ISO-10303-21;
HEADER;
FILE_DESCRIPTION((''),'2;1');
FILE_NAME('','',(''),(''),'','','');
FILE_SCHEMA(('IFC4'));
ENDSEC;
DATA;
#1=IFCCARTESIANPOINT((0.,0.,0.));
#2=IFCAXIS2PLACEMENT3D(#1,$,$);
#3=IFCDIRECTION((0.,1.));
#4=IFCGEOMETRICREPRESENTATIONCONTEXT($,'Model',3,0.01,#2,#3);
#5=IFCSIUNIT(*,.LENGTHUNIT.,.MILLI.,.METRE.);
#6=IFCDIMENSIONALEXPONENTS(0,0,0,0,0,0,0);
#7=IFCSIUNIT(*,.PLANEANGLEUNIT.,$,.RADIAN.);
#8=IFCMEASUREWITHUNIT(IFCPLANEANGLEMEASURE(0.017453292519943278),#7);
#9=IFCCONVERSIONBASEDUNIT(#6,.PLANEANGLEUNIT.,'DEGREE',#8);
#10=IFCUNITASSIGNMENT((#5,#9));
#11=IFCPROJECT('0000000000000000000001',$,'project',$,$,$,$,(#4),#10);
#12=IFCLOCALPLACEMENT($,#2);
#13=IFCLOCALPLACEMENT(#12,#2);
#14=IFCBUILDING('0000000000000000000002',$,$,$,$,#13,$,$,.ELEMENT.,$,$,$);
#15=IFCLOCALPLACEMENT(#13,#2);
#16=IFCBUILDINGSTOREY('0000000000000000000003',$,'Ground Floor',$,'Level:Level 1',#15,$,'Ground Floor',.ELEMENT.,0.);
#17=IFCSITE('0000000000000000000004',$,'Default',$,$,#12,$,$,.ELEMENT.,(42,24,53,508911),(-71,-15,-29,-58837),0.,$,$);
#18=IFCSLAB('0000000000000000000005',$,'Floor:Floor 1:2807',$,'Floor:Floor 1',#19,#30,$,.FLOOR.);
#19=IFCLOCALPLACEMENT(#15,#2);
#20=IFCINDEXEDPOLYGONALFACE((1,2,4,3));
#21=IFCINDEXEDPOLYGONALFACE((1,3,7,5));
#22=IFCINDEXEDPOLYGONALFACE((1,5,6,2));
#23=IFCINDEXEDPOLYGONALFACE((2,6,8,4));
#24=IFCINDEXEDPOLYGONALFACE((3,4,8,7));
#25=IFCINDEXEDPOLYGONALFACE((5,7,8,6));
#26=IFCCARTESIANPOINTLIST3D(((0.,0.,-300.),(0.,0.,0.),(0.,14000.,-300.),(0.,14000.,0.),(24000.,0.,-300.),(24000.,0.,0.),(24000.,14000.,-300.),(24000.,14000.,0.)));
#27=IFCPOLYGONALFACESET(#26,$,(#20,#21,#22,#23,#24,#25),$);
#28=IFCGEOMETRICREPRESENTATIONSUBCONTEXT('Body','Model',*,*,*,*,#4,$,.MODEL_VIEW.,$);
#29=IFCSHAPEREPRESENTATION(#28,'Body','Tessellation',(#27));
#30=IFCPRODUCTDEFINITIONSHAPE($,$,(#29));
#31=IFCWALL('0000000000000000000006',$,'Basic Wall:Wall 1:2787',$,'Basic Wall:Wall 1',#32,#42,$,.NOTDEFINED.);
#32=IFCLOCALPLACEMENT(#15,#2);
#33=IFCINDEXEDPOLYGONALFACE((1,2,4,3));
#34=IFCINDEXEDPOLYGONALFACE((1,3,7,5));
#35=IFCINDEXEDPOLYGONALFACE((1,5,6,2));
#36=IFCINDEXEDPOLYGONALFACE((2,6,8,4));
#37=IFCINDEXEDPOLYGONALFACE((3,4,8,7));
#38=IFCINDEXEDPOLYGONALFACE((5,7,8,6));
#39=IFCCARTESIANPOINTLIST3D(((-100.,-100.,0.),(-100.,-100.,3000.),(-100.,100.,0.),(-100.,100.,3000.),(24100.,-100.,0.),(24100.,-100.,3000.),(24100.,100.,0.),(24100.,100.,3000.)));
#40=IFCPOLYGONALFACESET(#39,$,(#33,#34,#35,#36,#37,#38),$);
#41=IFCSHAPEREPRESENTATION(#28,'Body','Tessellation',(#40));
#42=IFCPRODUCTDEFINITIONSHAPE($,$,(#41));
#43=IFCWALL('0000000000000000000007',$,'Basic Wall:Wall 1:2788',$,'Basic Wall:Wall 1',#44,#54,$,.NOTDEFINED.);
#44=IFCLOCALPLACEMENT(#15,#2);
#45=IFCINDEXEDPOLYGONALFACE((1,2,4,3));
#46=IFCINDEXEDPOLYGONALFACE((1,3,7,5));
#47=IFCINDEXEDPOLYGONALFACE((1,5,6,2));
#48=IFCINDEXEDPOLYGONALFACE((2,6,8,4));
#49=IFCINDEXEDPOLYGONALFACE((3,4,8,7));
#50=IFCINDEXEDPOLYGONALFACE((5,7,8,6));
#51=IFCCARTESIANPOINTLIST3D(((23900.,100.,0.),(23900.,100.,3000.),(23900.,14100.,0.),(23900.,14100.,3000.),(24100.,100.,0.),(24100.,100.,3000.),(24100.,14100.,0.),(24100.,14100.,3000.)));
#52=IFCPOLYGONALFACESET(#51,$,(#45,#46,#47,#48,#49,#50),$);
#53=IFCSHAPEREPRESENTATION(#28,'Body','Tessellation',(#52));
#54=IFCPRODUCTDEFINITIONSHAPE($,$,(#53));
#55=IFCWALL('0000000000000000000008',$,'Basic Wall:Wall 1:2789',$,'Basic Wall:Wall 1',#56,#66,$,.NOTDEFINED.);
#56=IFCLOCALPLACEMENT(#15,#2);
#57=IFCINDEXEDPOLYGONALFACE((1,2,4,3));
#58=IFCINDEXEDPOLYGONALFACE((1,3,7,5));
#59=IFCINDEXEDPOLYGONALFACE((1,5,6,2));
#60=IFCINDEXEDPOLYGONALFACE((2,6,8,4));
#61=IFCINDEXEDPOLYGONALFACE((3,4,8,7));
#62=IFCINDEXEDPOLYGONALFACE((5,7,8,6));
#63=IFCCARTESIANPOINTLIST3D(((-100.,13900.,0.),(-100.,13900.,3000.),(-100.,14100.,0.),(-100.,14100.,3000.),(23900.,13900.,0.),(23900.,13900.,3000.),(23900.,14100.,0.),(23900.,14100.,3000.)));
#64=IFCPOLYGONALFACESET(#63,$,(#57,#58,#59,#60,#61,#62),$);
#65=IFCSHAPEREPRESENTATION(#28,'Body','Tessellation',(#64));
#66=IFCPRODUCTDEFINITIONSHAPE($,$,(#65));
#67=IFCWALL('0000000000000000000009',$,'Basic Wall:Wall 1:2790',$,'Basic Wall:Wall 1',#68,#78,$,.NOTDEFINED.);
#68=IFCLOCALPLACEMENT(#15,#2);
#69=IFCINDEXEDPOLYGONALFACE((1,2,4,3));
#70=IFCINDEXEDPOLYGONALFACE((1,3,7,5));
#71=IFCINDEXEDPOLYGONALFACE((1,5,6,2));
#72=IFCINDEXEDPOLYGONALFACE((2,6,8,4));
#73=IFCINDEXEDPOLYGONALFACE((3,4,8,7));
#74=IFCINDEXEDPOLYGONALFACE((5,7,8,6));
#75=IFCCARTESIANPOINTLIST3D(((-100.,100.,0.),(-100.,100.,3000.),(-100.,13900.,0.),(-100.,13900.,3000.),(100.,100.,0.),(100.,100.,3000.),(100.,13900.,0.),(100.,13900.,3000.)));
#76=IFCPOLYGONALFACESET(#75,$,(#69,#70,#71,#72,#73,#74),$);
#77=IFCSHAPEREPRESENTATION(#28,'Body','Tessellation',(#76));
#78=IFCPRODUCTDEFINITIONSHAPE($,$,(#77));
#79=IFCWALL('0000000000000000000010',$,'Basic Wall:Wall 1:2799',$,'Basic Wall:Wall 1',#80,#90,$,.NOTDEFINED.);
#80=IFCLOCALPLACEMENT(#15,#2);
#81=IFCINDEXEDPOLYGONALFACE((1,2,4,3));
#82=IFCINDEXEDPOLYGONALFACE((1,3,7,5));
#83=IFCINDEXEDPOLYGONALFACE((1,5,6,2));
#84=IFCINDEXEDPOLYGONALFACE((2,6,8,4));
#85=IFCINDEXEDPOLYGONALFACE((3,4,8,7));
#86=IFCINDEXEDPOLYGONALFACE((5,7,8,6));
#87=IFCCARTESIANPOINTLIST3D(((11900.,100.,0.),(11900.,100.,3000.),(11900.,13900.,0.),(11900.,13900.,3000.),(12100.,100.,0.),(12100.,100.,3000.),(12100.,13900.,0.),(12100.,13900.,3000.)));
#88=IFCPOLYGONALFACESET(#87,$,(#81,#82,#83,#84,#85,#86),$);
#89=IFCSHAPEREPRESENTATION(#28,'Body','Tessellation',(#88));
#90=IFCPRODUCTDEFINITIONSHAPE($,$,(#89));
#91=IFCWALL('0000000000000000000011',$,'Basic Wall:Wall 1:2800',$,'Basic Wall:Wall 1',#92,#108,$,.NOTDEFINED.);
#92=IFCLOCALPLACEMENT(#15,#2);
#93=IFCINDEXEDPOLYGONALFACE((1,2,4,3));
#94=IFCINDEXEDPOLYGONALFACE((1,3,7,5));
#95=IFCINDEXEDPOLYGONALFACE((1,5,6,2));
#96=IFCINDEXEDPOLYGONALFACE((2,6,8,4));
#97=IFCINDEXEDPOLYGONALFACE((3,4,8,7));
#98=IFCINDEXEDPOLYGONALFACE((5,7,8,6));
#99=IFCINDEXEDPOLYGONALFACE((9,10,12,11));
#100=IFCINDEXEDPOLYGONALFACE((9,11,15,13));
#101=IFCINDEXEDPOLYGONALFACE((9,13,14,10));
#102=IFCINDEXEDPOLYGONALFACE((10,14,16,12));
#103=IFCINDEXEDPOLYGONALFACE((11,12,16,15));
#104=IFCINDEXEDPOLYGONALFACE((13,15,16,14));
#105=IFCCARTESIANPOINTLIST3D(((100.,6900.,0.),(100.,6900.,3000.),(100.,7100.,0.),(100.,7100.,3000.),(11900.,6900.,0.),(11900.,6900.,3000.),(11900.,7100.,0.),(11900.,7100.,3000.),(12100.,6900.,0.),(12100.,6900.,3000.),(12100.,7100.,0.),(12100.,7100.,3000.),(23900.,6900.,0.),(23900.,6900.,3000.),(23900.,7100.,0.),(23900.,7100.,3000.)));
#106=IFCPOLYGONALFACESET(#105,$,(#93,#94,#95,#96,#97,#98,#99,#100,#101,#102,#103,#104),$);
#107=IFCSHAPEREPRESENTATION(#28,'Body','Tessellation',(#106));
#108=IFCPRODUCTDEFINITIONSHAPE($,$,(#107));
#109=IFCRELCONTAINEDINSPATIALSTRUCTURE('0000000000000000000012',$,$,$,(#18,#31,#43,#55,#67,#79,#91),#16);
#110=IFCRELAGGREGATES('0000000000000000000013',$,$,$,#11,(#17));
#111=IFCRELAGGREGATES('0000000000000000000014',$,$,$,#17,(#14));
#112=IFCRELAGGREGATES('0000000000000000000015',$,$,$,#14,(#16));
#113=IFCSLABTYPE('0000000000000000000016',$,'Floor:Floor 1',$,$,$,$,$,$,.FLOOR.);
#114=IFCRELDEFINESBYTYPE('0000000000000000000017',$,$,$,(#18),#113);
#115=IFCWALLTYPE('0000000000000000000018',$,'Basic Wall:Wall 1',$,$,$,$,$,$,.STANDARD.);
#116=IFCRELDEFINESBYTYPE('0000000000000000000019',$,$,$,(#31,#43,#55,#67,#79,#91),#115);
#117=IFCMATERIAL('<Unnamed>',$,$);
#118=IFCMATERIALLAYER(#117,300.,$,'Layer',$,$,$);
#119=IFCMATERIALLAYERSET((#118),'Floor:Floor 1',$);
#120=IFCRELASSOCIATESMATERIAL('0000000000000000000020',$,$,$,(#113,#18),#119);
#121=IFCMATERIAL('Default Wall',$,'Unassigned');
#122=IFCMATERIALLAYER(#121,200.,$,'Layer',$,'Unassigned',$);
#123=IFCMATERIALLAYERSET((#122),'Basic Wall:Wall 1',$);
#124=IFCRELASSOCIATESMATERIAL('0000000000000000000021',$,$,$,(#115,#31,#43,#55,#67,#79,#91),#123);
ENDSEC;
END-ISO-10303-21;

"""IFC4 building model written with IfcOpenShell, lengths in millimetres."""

from ifc_helpers import new_model, entity, si_unit, converted_unit, direction, frame, frame_2d, origin, origin_2d_with_axis, place, context, subcontext, project, spatial, rectangle, extrude, material, layer, layer_set, layer_usage, type_object, element, save


model = new_model("IFC4")

# Units and contexts
model_context = context("Model", 3, precision=0.01, world=origin(), true_north=direction((0.0, 1.0)))
body_context = subcontext(model_context, "Body", "Model", "MODEL_VIEW")
ifc_project = project(units=[si_unit("LENGTHUNIT", "METRE", prefix="MILLI"), converted_unit("PLANEANGLEUNIT", "DEGREE", entity("IfcPlaneAngleMeasure", 0.017453292519943278), si_unit("PLANEANGLEUNIT", "RADIAN"), dimensions=[0, 0, 0, 0, 0, 0, 0])], contexts=[model_context])

# Site, building, storey
site_placement = place(None, origin())
site = spatial("IfcSite", under=ifc_project, at=site_placement, Name="Default", CompositionType="ELEMENT", RefLatitude=(42, 24, 53, 508911), RefLongitude=(-71, -15, -29, -58837), RefElevation=0.0)
building_placement = place(site_placement, origin())
building = spatial("IfcBuilding", under=site, at=building_placement, CompositionType="ELEMENT")
storey_placement = place(building_placement, origin())
storey = spatial("IfcBuildingStorey", under=building, at=storey_placement, Name="Ground Floor", ObjectType="Level:Level 1", LongName="Ground Floor", CompositionType="ELEMENT", Elevation=0.0)

# Shared definitions
ifc_material_1 = material(Name="Default Wall", Category="Unassigned")

# Slab
ifc_material_2 = material(Name="<Unnamed>")
ifc_layer_1 = layer(ifc_material_2, 300.0, Name="Layer")
ifc_layer_set_1 = layer_set([ifc_layer_1], Name="Floor:Floor 1")
ifc_layer_usage_1 = layer_usage(ifc_layer_set_1, "AXIS3", "POSITIVE", 0.0)
slab_type = type_object("IfcSlabType", Name="Floor:Floor 1", PredefinedType="FLOOR", material=ifc_layer_set_1)
slab_placement = place(storey_placement, origin())
element("IfcSlab", 1, at=slab_placement, inside=storey, type_object=slab_type, material=ifc_layer_usage_1, Name="Floor:Floor 1:2807", ObjectType="Floor:Floor 1", PredefinedType="FLOOR", context=body_context, shape_type="SweptSolid", body=[
    extrude(rectangle(XDim=14000.0, YDim=24000.0, at=origin_2d_with_axis()), frame((12000.0, 7000.0, 0.0), z_axis=(0.0, 0.0, -1.0), x_axis=(0.0, 1.0, 0.0)), (0.0, 0.0, 1.0), 300.0),
])

# Walls
ifc_layer_2 = layer(ifc_material_1, 200.0, Name="Layer", Category="Unassigned")
ifc_layer_set_2 = layer_set([ifc_layer_2], Name="Basic Wall:Wall 1")
ifc_layer_usage_2 = layer_usage(ifc_layer_set_2, "AXIS2", "NEGATIVE", 100.0)
wall_type = type_object("IfcWallType", Name="Basic Wall:Wall 1", PredefinedType="STANDARD", material=ifc_layer_set_2)
wall_1_placement = place(storey_placement, frame((-100.0, 0.0, 0.0)))
element("IfcWall", 2, at=wall_1_placement, inside=storey, type_object=wall_type, material=ifc_layer_usage_2, Name="Basic Wall:Wall 1:2787", ObjectType="Basic Wall:Wall 1", PredefinedType="NOTDEFINED", context=body_context, shape_type="SweptSolid", body=[
    extrude(rectangle(XDim=24200.0, YDim=200.0, at=frame_2d((12100.0, 0.0), x_axis=(-1.0, 0.0))), origin(), (0.0, 0.0, 1.0), 3000.0),
])
ifc_layer_usage_3 = layer_usage(ifc_layer_set_2, "AXIS2", "NEGATIVE", 100.0)
wall_2_placement = place(storey_placement, frame((24000.0, 100.0, 0.0), z_axis=(0.0, 0.0, 1.0), x_axis=(0.0, 1.0, 0.0)))
element("IfcWall", 3, at=wall_2_placement, inside=storey, type_object=wall_type, material=ifc_layer_usage_3, Name="Basic Wall:Wall 1:2788", ObjectType="Basic Wall:Wall 1", PredefinedType="NOTDEFINED", context=body_context, shape_type="SweptSolid", body=[
    extrude(rectangle(XDim=14000.0, YDim=200.0, at=frame_2d((7000.0, 0.0), x_axis=(-1.0, 0.0))), origin(), (0.0, 0.0, 1.0), 3000.0),
])
ifc_layer_usage_4 = layer_usage(ifc_layer_set_2, "AXIS2", "NEGATIVE", 100.0)
wall_3_placement = place(storey_placement, frame((23900.0, 14000.0, 0.0), z_axis=(0.0, 0.0, 1.0), x_axis=(-1.0, 0.0, 0.0)))
element("IfcWall", 4, at=wall_3_placement, inside=storey, type_object=wall_type, material=ifc_layer_usage_4, Name="Basic Wall:Wall 1:2789", ObjectType="Basic Wall:Wall 1", PredefinedType="NOTDEFINED", context=body_context, shape_type="SweptSolid", body=[
    extrude(rectangle(XDim=24000.0, YDim=200.0, at=frame_2d((12000.0, 0.0), x_axis=(-1.0, 0.0))), origin(), (0.0, 0.0, 1.0), 3000.0),
])
ifc_layer_usage_5 = layer_usage(ifc_layer_set_2, "AXIS2", "NEGATIVE", 100.0)
wall_4_placement = place(storey_placement, frame((0.0, 13900.0, 0.0), z_axis=(0.0, 0.0, 1.0), x_axis=(0.0, -1.0, 0.0)))
element("IfcWall", 5, at=wall_4_placement, inside=storey, type_object=wall_type, material=ifc_layer_usage_5, Name="Basic Wall:Wall 1:2790", ObjectType="Basic Wall:Wall 1", PredefinedType="NOTDEFINED", context=body_context, shape_type="SweptSolid", body=[
    extrude(rectangle(XDim=13800.0, YDim=200.0, at=frame_2d((6900.0, 0.0), x_axis=(-1.0, 0.0))), origin(), (0.0, 0.0, 1.0), 3000.0),
])
ifc_layer_usage_6 = layer_usage(ifc_layer_set_2, "AXIS2", "NEGATIVE", 100.0)
wall_5_placement = place(storey_placement, frame((12000.0, 100.0, 0.0), z_axis=(0.0, 0.0, 1.0), x_axis=(0.0, 1.0, 0.0)))
element("IfcWall", 6, at=wall_5_placement, inside=storey, type_object=wall_type, material=ifc_layer_usage_6, Name="Basic Wall:Wall 1:2799", ObjectType="Basic Wall:Wall 1", PredefinedType="NOTDEFINED", context=body_context, shape_type="SweptSolid", body=[
    extrude(rectangle(XDim=13800.0, YDim=200.0, at=frame_2d((6900.0, 0.0), x_axis=(-1.0, 0.0))), origin(), (0.0, 0.0, 1.0), 3000.0),
])

# Wall, opening
ifc_layer_usage_7 = layer_usage(ifc_layer_set_2, "AXIS2", "NEGATIVE", 100.0)
wall_6_placement = place(storey_placement, frame((100.0, 7000.0, 0.0)))
wall_6 = element("IfcWall", 7, at=wall_6_placement, inside=storey, type_object=wall_type, material=ifc_layer_usage_7, Name="Basic Wall:Wall 1:2800", ObjectType="Basic Wall:Wall 1", PredefinedType="NOTDEFINED", context=body_context, shape_type="SweptSolid", body=[
    extrude(rectangle(XDim=23800.0, YDim=200.0, at=frame_2d((11900.0, 0.0), x_axis=(-1.0, 0.0))), origin(), (0.0, 0.0, 1.0), 3000.0),
])
opening_placement = place(storey_placement, frame((100.0, 7000.0, 0.0)))
element("IfcOpeningElement", 8, at=opening_placement, cuts=wall_6, PredefinedType="OPENING", context=body_context, shape_type="SweptSolid", body=[
    extrude(rectangle(XDim=3000.0, YDim=200.0, at=frame_2d((0.0, 0.0), x_axis=(1.0, 0.0))), frame((11800.0, 0.0, 1500.0), z_axis=(1.0, 0.0, 0.0), x_axis=(0.0, 0.0, -1.0)), (0.0, 0.0, 1.0), 200.0),
])

save(model, "model.ifc")
